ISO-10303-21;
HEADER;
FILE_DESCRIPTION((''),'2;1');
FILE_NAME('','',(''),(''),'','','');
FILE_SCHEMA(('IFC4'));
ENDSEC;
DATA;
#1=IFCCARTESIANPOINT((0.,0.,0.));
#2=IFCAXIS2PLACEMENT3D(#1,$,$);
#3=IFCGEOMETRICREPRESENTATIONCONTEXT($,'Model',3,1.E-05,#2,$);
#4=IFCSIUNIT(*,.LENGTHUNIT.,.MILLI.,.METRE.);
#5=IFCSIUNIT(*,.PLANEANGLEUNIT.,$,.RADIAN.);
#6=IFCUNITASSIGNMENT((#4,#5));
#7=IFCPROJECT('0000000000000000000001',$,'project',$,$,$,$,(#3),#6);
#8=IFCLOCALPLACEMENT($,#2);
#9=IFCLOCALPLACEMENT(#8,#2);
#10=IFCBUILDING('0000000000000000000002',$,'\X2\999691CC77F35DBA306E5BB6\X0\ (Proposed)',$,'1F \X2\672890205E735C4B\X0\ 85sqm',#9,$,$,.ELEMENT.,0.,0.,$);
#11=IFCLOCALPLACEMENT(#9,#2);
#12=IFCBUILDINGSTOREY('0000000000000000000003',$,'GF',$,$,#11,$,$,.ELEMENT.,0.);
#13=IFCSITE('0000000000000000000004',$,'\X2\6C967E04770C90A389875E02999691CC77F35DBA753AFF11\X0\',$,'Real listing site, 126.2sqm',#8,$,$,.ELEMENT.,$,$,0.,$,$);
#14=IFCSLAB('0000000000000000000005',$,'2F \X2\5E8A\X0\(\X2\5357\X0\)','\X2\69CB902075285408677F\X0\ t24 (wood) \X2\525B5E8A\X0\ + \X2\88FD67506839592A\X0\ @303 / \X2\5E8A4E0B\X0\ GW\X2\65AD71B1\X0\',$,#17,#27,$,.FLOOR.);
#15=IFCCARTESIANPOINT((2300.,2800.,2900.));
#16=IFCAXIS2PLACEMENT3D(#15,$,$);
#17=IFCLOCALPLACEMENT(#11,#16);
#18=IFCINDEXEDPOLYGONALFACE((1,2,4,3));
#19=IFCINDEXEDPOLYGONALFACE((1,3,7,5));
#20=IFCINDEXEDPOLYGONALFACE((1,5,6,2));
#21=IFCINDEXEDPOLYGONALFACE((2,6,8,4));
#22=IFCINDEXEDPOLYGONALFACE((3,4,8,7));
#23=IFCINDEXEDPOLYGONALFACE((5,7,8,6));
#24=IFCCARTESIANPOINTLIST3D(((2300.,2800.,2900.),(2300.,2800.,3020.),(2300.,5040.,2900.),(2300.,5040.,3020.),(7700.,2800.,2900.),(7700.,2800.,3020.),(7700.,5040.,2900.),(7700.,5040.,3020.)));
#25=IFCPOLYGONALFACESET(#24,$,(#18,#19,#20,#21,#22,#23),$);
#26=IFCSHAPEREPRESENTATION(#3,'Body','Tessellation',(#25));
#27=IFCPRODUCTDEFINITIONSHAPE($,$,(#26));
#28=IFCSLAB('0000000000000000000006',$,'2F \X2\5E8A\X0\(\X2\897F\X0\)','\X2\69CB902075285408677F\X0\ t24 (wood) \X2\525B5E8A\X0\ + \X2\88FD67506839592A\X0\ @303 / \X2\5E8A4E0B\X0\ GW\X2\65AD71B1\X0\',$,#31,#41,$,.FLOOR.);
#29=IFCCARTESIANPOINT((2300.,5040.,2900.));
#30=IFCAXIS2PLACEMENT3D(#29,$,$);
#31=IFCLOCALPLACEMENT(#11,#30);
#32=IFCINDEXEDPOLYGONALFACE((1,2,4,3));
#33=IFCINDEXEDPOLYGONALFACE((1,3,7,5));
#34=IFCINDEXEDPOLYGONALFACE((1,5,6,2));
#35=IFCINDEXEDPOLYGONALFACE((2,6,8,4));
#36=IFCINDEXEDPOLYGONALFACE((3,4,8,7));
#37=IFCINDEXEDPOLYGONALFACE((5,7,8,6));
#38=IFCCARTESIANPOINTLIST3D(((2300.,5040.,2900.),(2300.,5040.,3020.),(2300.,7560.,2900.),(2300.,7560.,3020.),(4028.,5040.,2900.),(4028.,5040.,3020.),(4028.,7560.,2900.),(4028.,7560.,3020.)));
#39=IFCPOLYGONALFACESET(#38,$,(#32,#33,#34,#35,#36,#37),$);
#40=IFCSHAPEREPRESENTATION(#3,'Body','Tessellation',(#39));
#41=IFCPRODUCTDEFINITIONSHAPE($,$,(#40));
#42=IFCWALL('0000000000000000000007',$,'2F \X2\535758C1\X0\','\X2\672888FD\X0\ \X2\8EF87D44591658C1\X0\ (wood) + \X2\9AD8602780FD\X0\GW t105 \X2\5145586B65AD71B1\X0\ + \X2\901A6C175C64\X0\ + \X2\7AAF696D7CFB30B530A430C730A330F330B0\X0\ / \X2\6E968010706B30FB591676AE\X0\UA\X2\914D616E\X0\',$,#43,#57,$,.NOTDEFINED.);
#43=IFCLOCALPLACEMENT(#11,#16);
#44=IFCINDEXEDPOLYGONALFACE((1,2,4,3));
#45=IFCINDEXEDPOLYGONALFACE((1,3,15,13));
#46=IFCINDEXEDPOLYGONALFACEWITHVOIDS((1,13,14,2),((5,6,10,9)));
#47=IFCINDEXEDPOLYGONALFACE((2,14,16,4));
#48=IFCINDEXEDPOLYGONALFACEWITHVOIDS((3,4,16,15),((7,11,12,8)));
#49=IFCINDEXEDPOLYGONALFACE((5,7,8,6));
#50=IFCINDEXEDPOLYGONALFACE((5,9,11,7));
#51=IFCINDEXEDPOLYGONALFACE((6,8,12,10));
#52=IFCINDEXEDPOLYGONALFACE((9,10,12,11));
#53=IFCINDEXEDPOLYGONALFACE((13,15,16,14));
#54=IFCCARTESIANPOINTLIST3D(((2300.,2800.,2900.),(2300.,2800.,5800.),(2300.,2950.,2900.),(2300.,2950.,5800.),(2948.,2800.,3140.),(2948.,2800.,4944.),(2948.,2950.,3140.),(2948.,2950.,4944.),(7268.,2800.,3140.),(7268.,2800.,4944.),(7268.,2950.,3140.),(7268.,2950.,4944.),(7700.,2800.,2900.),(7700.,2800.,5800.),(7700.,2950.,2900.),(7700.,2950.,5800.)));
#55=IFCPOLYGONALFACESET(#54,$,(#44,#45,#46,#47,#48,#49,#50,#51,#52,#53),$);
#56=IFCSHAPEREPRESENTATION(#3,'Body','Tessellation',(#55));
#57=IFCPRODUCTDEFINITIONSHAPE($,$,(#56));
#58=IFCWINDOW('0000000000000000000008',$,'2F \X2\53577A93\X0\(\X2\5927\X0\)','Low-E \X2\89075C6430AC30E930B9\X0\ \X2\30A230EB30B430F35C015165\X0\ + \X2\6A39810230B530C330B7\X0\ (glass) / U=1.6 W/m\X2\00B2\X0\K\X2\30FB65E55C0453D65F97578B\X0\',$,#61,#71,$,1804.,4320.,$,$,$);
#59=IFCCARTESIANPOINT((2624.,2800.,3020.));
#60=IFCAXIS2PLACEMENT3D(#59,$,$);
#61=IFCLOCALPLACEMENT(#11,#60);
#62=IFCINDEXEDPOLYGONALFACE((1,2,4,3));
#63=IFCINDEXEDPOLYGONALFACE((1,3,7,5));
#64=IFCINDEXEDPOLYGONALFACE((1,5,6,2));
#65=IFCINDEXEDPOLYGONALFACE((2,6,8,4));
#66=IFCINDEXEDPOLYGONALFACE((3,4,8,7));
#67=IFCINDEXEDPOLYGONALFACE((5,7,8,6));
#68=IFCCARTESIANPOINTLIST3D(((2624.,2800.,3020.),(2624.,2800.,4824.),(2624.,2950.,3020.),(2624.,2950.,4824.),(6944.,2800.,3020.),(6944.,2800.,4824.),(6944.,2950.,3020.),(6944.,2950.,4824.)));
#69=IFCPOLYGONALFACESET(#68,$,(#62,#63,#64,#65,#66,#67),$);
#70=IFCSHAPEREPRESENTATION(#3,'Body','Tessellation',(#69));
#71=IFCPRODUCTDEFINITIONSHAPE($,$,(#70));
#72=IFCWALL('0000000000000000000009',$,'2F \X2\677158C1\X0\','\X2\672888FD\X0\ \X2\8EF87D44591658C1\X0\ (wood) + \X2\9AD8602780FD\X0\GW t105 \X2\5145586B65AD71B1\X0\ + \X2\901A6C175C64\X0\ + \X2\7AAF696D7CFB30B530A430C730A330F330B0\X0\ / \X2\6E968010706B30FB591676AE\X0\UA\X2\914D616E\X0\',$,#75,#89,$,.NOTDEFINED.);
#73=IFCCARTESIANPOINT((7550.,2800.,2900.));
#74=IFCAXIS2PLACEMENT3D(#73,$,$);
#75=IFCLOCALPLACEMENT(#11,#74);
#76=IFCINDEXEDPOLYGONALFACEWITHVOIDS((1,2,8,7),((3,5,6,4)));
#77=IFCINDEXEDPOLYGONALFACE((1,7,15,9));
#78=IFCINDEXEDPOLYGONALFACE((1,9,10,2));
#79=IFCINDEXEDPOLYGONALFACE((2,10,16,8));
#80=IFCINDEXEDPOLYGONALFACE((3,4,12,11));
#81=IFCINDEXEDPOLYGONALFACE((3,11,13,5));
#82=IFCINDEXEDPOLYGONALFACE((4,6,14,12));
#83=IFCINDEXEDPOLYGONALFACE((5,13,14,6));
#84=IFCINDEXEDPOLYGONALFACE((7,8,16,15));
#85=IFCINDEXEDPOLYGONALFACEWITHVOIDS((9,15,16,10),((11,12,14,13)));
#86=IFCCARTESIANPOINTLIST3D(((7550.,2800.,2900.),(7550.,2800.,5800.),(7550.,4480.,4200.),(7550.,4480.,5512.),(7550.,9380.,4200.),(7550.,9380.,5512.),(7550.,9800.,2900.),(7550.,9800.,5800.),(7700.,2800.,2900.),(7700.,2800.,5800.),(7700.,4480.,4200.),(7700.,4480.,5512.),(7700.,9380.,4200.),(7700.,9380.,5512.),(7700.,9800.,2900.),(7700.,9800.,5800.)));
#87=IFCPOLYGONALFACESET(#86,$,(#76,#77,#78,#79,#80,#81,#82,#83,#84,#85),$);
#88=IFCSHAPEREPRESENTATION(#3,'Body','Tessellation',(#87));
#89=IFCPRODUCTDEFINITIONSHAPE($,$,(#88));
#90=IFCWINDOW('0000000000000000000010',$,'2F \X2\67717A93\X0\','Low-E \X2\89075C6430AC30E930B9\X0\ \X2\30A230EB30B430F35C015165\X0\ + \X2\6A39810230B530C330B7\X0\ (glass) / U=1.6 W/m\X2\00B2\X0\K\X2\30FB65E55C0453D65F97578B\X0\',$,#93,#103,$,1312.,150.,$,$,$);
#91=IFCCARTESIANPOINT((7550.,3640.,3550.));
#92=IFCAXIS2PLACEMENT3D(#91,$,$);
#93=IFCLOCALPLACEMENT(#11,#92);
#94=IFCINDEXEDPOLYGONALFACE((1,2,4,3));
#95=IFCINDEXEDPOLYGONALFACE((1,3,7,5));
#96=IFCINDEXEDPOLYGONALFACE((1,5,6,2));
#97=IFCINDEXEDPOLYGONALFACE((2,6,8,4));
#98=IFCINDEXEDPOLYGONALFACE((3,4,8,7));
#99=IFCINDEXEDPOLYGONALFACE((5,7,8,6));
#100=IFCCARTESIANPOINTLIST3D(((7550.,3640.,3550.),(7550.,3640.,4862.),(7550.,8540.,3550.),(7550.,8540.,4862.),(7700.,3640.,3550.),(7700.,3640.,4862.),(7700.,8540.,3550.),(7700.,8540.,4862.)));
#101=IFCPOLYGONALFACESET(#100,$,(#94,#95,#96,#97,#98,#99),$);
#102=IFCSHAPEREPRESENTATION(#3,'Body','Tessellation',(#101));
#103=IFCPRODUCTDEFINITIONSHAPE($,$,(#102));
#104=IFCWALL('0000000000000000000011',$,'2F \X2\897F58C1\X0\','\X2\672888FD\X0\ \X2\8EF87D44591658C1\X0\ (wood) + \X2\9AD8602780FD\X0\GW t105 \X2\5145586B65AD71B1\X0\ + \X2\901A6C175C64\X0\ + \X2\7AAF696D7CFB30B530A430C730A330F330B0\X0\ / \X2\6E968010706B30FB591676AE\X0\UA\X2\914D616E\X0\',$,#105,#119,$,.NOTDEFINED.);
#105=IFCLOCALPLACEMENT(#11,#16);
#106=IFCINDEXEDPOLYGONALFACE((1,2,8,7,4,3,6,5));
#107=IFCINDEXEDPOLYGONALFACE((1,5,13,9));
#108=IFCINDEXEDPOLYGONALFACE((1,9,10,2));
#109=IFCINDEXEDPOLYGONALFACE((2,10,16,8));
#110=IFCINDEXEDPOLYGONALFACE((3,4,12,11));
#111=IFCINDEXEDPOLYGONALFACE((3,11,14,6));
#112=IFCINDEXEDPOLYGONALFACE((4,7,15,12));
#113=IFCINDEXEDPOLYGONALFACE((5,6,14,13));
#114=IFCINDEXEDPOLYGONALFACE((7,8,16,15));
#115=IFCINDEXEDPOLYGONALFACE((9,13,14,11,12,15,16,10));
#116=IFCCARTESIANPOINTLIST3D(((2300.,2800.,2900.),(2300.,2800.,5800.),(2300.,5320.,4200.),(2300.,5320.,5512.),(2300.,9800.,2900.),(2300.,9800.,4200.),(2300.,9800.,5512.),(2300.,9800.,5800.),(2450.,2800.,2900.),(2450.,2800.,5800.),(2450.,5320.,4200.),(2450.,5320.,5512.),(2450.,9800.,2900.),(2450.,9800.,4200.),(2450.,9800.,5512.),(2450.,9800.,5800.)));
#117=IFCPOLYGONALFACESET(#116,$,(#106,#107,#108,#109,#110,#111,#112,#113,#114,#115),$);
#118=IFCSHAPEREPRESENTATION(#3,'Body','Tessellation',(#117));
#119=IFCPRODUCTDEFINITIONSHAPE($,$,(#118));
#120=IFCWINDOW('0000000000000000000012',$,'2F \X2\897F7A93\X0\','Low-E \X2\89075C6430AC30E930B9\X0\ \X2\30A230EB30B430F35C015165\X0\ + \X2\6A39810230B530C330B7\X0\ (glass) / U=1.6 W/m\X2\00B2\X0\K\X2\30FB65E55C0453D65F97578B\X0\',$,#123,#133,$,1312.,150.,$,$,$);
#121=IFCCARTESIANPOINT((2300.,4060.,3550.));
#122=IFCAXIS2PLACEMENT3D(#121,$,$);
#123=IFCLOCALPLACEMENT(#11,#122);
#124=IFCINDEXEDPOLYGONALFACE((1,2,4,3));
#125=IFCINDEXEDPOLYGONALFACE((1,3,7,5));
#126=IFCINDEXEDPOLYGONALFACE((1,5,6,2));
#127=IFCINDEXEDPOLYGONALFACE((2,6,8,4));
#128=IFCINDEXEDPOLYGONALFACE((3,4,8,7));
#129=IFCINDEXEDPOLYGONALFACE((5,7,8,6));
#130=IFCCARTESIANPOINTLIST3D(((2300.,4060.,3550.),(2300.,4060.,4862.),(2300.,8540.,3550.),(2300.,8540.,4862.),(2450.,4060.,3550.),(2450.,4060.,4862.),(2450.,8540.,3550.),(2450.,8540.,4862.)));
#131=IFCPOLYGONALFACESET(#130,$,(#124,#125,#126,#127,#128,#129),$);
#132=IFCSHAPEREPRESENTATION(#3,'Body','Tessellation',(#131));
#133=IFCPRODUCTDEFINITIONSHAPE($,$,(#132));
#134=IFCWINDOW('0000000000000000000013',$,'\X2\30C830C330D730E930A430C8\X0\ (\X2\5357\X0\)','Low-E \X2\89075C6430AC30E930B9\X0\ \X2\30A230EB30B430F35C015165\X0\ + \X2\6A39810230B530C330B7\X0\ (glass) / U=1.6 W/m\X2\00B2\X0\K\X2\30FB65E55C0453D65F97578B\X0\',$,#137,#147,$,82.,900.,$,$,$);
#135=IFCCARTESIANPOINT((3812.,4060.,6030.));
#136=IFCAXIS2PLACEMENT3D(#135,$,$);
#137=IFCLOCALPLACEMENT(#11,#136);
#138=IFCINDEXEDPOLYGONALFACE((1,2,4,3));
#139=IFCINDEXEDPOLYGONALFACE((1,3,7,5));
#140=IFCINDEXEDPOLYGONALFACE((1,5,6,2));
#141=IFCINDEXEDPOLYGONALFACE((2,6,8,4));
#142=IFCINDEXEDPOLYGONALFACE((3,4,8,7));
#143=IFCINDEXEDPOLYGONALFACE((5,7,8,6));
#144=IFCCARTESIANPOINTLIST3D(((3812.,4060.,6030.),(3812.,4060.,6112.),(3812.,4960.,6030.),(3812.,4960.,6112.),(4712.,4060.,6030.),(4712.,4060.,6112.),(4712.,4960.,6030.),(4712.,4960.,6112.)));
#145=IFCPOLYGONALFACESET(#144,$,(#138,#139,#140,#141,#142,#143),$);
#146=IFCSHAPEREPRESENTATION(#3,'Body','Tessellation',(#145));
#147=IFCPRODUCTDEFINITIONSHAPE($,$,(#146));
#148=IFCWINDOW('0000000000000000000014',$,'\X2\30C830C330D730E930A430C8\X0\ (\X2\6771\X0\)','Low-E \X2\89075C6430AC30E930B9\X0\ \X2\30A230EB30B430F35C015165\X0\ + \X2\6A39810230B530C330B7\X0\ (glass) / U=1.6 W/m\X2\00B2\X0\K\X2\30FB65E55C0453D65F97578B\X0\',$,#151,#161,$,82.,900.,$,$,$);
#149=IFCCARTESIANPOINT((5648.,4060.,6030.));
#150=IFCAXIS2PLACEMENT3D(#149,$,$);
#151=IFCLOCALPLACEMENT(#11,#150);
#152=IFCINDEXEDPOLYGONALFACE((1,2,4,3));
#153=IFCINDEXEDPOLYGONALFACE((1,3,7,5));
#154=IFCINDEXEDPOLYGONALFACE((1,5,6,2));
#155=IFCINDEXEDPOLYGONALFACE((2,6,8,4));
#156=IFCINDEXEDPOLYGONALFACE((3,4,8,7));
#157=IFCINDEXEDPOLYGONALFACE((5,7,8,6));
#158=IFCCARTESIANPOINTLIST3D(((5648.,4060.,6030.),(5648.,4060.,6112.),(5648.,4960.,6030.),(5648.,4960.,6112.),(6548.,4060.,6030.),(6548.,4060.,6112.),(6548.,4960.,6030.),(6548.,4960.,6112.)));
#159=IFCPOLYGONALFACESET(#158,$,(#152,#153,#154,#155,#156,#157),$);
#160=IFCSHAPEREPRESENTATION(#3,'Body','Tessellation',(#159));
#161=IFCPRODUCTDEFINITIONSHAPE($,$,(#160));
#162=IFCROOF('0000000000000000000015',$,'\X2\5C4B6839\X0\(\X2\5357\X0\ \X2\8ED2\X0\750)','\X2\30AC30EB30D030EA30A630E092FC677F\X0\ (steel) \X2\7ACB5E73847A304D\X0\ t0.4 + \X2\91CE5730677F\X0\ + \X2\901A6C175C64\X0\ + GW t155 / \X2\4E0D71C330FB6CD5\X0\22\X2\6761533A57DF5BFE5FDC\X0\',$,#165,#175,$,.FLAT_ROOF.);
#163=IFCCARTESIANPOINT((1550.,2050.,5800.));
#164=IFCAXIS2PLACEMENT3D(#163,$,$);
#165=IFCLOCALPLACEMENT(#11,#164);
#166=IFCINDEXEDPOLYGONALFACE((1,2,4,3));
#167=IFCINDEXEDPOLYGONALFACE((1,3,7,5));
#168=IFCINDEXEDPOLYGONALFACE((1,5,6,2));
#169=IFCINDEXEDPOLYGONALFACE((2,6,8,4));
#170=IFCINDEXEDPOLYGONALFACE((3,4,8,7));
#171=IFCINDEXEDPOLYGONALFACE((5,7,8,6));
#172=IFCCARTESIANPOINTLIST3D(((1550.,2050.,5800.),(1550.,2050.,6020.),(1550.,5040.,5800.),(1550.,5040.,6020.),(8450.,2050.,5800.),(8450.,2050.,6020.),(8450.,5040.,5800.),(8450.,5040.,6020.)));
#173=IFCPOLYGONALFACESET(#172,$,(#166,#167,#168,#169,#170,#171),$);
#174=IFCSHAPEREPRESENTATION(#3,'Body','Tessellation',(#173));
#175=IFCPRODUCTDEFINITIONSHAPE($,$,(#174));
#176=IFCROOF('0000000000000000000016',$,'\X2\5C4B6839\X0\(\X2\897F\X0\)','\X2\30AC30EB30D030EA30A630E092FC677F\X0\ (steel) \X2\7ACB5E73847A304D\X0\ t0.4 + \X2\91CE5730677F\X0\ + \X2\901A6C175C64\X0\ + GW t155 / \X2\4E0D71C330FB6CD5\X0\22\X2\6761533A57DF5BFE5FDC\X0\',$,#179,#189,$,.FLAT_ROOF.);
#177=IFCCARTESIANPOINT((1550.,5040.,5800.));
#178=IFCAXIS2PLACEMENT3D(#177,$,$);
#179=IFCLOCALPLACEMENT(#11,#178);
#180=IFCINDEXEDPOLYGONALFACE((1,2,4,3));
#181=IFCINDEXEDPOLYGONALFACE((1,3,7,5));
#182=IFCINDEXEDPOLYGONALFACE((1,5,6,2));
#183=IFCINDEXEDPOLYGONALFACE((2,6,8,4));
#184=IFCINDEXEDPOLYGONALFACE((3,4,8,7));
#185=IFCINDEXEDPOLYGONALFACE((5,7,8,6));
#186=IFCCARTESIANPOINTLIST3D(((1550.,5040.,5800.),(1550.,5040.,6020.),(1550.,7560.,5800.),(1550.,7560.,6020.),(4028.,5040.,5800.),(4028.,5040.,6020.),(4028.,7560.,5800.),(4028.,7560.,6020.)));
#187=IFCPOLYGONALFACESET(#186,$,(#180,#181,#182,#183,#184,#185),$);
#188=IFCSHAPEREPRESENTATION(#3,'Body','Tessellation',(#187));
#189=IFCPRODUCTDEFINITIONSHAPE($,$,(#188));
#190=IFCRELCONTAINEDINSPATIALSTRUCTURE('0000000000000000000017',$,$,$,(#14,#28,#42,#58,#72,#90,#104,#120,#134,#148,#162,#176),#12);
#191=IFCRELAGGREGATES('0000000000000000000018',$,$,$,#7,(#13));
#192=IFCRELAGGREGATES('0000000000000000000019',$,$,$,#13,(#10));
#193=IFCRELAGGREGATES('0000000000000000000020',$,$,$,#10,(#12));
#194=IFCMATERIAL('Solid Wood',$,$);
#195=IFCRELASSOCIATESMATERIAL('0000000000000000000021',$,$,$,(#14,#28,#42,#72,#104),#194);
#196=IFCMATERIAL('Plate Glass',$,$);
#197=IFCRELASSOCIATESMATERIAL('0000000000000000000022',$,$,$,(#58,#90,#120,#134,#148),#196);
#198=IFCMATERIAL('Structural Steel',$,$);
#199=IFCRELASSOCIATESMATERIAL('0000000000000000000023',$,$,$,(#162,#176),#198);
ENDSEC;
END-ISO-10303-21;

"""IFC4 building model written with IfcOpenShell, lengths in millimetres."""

from ifc_helpers import new_model, si_unit, frame, frame_2d, origin, place, context, project, spatial, rectangle, extrude, material, element, fill, save


model = new_model("IFC4")

# Units and contexts
model_context = context("Model", 3, precision=1e-05, world=origin())
ifc_project = project(units=[si_unit("LENGTHUNIT", "METRE", prefix="MILLI"), si_unit("PLANEANGLEUNIT", "RADIAN")], contexts=[model_context])

# Site, building, storey
site_placement = place(None, origin())
site = spatial("IfcSite", under=ifc_project, at=site_placement, Name="沖縄県那覇市首里石嶺町１", ObjectType="Real listing site, 126.2sqm", CompositionType="ELEMENT", RefElevation=0.0)
building_placement = place(site_placement, origin())
building = spatial("IfcBuilding", under=site, at=building_placement, Name="首里石嶺の家 (Proposed)", ObjectType="1F 木造平屋 85sqm", CompositionType="ELEMENT", ElevationOfRefHeight=0.0, ElevationOfTerrain=0.0)
storey_placement = place(building_placement, origin())
storey = spatial("IfcBuildingStorey", under=building, at=storey_placement, Name="GF", CompositionType="ELEMENT", Elevation=0.0)

# Slabs
ifc_material_1 = material(Name="Solid Wood")
slab_1_placement = place(storey_placement, frame((2300.0, 2800.0, 2900.0)))
element("IfcSlab", 1, at=slab_1_placement, inside=storey, material=ifc_material_1, Name="2F 床(南)", Description="構造用合板 t24 (wood) 剛床 + 製材根太 @303 / 床下 GW断熱", PredefinedType="FLOOR", context=model_context, shape_type="SweptSolid", body=[
    extrude(rectangle(XDim=5400.0, YDim=2240.0, at=frame_2d((2700.0, 1120.0))), frame((2300.0, 2800.0, 2900.0)), (0.0, 0.0, 1.0), 120.0),
])
slab_2_placement = place(storey_placement, frame((2300.0, 5040.0, 2900.0)))
element("IfcSlab", 2, at=slab_2_placement, inside=storey, material=ifc_material_1, Name="2F 床(西)", Description="構造用合板 t24 (wood) 剛床 + 製材根太 @303 / 床下 GW断熱", PredefinedType="FLOOR", context=model_context, shape_type="SweptSolid", body=[
    extrude(rectangle(XDim=1728.0, YDim=2520.0, at=frame_2d((864.0, 1260.0))), frame((2300.0, 5040.0, 2900.0)), (0.0, 0.0, 1.0), 120.0),
])

# Walls, openings, windows
wall_1_placement = place(storey_placement, frame((2300.0, 2800.0, 2900.0)))
wall_1 = element("IfcWall", 3, at=wall_1_placement, inside=storey, material=ifc_material_1, Name="2F 南壁", Description="木製 軸組外壁 (wood) + 高性能GW t105 充填断熱 + 通気層 + 窯業系サイディング / 準耐火・外皮UA配慮", PredefinedType="NOTDEFINED", context=model_context, shape_type="SweptSolid", body=[
    extrude(rectangle(XDim=5400.0, YDim=150.0, at=frame_2d((2700.0, 75.0))), frame((2300.0, 2800.0, 2900.0)), (0.0, 0.0, 1.0), 2900.0),
])
opening_1_placement = place(storey_placement, frame((2624.0, 2800.0, 3020.0)))
opening_1 = element("IfcOpeningElement", 4, at=opening_1_placement, cuts=wall_1, PredefinedType="NOTDEFINED", context=model_context, shape_type="SweptSolid", body=[
    extrude(rectangle(XDim=4320.0, YDim=150.0, at=frame_2d((2160.0, 75.0))), frame((2624.0, 2800.0, 3020.0)), (0.0, 0.0, 1.0), 1804.0),
])
ifc_material_2 = material(Name="Plate Glass")
window_1_placement = place(storey_placement, frame((2624.0, 2800.0, 3020.0)))
window_1 = element("IfcWindow", 5, at=window_1_placement, inside=storey, material=ifc_material_2, Name="2F 南窓(大)", Description="Low-E 複層ガラス アルゴン封入 + 樹脂サッシ (glass) / U=1.6 W/m²K・日射取得型", OverallHeight=1804.0, OverallWidth=4320.0, context=model_context, shape_type="SweptSolid", body=[
    extrude(rectangle(XDim=4320.0, YDim=150.0, at=frame_2d((2160.0, 75.0))), frame((2624.0, 2800.0, 3020.0)), (0.0, 0.0, 1.0), 1804.0),
])
fill(opening_1, window_1)
wall_2_placement = place(storey_placement, frame((7550.0, 2800.0, 2900.0)))
wall_2 = element("IfcWall", 6, at=wall_2_placement, inside=storey, material=ifc_material_1, Name="2F 東壁", Description="木製 軸組外壁 (wood) + 高性能GW t105 充填断熱 + 通気層 + 窯業系サイディング / 準耐火・外皮UA配慮", PredefinedType="NOTDEFINED", context=model_context, shape_type="SweptSolid", body=[
    extrude(rectangle(XDim=150.0, YDim=7000.0, at=frame_2d((75.0, 3500.0))), frame((7550.0, 2800.0, 2900.0)), (0.0, 0.0, 1.0), 2900.0),
])
opening_2_placement = place(storey_placement, frame((7550.0, 3640.0, 3550.0)))
opening_2 = element("IfcOpeningElement", 7, at=opening_2_placement, cuts=wall_2, PredefinedType="NOTDEFINED", context=model_context, shape_type="SweptSolid", body=[
    extrude(rectangle(XDim=150.0, YDim=4900.0, at=frame_2d((75.0, 2450.0))), frame((7550.0, 3640.0, 3550.0)), (0.0, 0.0, 1.0), 1312.0),
])
window_2_placement = place(storey_placement, frame((7550.0, 3640.0, 3550.0)))
window_2 = element("IfcWindow", 8, at=window_2_placement, inside=storey, material=ifc_material_2, Name="2F 東窓", Description="Low-E 複層ガラス アルゴン封入 + 樹脂サッシ (glass) / U=1.6 W/m²K・日射取得型", OverallHeight=1312.0, OverallWidth=150.0, context=model_context, shape_type="SweptSolid", body=[
    extrude(rectangle(XDim=150.0, YDim=4900.0, at=frame_2d((75.0, 2450.0))), frame((7550.0, 3640.0, 3550.0)), (0.0, 0.0, 1.0), 1312.0),
])
fill(opening_2, window_2)
wall_3_placement = place(storey_placement, frame((2300.0, 2800.0, 2900.0)))
wall_3 = element("IfcWall", 9, at=wall_3_placement, inside=storey, material=ifc_material_1, Name="2F 西壁", Description="木製 軸組外壁 (wood) + 高性能GW t105 充填断熱 + 通気層 + 窯業系サイディング / 準耐火・外皮UA配慮", PredefinedType="NOTDEFINED", context=model_context, shape_type="SweptSolid", body=[
    extrude(rectangle(XDim=150.0, YDim=7000.0, at=frame_2d((75.0, 3500.0))), frame((2300.0, 2800.0, 2900.0)), (0.0, 0.0, 1.0), 2900.0),
])
opening_3_placement = place(storey_placement, frame((2300.0, 4060.0, 3550.0)))
opening_3 = element("IfcOpeningElement", 10, at=opening_3_placement, cuts=wall_3, PredefinedType="NOTDEFINED", context=model_context, shape_type="SweptSolid", body=[
    extrude(rectangle(XDim=150.0, YDim=4480.0, at=frame_2d((75.0, 2240.0))), frame((2300.0, 4060.0, 3550.0)), (0.0, 0.0, 1.0), 1312.0),
])
window_3_placement = place(storey_placement, frame((2300.0, 4060.0, 3550.0)))
window_3 = element("IfcWindow", 11, at=window_3_placement, inside=storey, material=ifc_material_2, Name="2F 西窓", Description="Low-E 複層ガラス アルゴン封入 + 樹脂サッシ (glass) / U=1.6 W/m²K・日射取得型", OverallHeight=1312.0, OverallWidth=150.0, context=model_context, shape_type="SweptSolid", body=[
    extrude(rectangle(XDim=150.0, YDim=4480.0, at=frame_2d((75.0, 2240.0))), frame((2300.0, 4060.0, 3550.0)), (0.0, 0.0, 1.0), 1312.0),
])
fill(opening_3, window_3)

# Windows
window_4_placement = place(storey_placement, frame((3812.0, 4060.0, 6030.0)))
element("IfcWindow", 12, at=window_4_placement, inside=storey, material=ifc_material_2, Name="トップライト (南)", Description="Low-E 複層ガラス アルゴン封入 + 樹脂サッシ (glass) / U=1.6 W/m²K・日射取得型", OverallHeight=82.0, OverallWidth=900.0, context=model_context, shape_type="SweptSolid", body=[
    extrude(rectangle(XDim=900.0, YDim=900.0, at=frame_2d((450.0, 450.0))), frame((3812.0, 4060.0, 6030.0)), (0.0, 0.0, 1.0), 82.0),
])
window_5_placement = place(storey_placement, frame((5648.0, 4060.0, 6030.0)))
element("IfcWindow", 13, at=window_5_placement, inside=storey, material=ifc_material_2, Name="トップライト (東)", Description="Low-E 複層ガラス アルゴン封入 + 樹脂サッシ (glass) / U=1.6 W/m²K・日射取得型", OverallHeight=82.0, OverallWidth=900.0, context=model_context, shape_type="SweptSolid", body=[
    extrude(rectangle(XDim=900.0, YDim=900.0, at=frame_2d((450.0, 450.0))), frame((5648.0, 4060.0, 6030.0)), (0.0, 0.0, 1.0), 82.0),
])

# Roofs
ifc_material_3 = material(Name="Structural Steel")
roof_1_placement = place(storey_placement, frame((1550.0, 2050.0, 5800.0)))
element("IfcRoof", 14, at=roof_1_placement, inside=storey, material=ifc_material_3, Name="屋根(南 軒750)", Description="ガルバリウム鋼板 (steel) 立平葺き t0.4 + 野地板 + 通気層 + GW t155 / 不燃・法22条区域対応", PredefinedType="FLAT_ROOF", context=model_context, shape_type="SweptSolid", body=[
    extrude(rectangle(XDim=6900.0, YDim=2990.0, at=frame_2d((3450.0, 1495.0))), frame((1550.0, 2050.0, 5800.0)), (0.0, 0.0, 1.0), 220.0),
])
roof_2_placement = place(storey_placement, frame((1550.0, 5040.0, 5800.0)))
element("IfcRoof", 15, at=roof_2_placement, inside=storey, material=ifc_material_3, Name="屋根(西)", Description="ガルバリウム鋼板 (steel) 立平葺き t0.4 + 野地板 + 通気層 + GW t155 / 不燃・法22条区域対応", PredefinedType="FLAT_ROOF", context=model_context, shape_type="SweptSolid", body=[
    extrude(rectangle(XDim=2478.0, YDim=2520.0, at=frame_2d((1239.0, 1260.0))), frame((1550.0, 5040.0, 5800.0)), (0.0, 0.0, 1.0), 220.0),
])

save(model, "model.ifc")
